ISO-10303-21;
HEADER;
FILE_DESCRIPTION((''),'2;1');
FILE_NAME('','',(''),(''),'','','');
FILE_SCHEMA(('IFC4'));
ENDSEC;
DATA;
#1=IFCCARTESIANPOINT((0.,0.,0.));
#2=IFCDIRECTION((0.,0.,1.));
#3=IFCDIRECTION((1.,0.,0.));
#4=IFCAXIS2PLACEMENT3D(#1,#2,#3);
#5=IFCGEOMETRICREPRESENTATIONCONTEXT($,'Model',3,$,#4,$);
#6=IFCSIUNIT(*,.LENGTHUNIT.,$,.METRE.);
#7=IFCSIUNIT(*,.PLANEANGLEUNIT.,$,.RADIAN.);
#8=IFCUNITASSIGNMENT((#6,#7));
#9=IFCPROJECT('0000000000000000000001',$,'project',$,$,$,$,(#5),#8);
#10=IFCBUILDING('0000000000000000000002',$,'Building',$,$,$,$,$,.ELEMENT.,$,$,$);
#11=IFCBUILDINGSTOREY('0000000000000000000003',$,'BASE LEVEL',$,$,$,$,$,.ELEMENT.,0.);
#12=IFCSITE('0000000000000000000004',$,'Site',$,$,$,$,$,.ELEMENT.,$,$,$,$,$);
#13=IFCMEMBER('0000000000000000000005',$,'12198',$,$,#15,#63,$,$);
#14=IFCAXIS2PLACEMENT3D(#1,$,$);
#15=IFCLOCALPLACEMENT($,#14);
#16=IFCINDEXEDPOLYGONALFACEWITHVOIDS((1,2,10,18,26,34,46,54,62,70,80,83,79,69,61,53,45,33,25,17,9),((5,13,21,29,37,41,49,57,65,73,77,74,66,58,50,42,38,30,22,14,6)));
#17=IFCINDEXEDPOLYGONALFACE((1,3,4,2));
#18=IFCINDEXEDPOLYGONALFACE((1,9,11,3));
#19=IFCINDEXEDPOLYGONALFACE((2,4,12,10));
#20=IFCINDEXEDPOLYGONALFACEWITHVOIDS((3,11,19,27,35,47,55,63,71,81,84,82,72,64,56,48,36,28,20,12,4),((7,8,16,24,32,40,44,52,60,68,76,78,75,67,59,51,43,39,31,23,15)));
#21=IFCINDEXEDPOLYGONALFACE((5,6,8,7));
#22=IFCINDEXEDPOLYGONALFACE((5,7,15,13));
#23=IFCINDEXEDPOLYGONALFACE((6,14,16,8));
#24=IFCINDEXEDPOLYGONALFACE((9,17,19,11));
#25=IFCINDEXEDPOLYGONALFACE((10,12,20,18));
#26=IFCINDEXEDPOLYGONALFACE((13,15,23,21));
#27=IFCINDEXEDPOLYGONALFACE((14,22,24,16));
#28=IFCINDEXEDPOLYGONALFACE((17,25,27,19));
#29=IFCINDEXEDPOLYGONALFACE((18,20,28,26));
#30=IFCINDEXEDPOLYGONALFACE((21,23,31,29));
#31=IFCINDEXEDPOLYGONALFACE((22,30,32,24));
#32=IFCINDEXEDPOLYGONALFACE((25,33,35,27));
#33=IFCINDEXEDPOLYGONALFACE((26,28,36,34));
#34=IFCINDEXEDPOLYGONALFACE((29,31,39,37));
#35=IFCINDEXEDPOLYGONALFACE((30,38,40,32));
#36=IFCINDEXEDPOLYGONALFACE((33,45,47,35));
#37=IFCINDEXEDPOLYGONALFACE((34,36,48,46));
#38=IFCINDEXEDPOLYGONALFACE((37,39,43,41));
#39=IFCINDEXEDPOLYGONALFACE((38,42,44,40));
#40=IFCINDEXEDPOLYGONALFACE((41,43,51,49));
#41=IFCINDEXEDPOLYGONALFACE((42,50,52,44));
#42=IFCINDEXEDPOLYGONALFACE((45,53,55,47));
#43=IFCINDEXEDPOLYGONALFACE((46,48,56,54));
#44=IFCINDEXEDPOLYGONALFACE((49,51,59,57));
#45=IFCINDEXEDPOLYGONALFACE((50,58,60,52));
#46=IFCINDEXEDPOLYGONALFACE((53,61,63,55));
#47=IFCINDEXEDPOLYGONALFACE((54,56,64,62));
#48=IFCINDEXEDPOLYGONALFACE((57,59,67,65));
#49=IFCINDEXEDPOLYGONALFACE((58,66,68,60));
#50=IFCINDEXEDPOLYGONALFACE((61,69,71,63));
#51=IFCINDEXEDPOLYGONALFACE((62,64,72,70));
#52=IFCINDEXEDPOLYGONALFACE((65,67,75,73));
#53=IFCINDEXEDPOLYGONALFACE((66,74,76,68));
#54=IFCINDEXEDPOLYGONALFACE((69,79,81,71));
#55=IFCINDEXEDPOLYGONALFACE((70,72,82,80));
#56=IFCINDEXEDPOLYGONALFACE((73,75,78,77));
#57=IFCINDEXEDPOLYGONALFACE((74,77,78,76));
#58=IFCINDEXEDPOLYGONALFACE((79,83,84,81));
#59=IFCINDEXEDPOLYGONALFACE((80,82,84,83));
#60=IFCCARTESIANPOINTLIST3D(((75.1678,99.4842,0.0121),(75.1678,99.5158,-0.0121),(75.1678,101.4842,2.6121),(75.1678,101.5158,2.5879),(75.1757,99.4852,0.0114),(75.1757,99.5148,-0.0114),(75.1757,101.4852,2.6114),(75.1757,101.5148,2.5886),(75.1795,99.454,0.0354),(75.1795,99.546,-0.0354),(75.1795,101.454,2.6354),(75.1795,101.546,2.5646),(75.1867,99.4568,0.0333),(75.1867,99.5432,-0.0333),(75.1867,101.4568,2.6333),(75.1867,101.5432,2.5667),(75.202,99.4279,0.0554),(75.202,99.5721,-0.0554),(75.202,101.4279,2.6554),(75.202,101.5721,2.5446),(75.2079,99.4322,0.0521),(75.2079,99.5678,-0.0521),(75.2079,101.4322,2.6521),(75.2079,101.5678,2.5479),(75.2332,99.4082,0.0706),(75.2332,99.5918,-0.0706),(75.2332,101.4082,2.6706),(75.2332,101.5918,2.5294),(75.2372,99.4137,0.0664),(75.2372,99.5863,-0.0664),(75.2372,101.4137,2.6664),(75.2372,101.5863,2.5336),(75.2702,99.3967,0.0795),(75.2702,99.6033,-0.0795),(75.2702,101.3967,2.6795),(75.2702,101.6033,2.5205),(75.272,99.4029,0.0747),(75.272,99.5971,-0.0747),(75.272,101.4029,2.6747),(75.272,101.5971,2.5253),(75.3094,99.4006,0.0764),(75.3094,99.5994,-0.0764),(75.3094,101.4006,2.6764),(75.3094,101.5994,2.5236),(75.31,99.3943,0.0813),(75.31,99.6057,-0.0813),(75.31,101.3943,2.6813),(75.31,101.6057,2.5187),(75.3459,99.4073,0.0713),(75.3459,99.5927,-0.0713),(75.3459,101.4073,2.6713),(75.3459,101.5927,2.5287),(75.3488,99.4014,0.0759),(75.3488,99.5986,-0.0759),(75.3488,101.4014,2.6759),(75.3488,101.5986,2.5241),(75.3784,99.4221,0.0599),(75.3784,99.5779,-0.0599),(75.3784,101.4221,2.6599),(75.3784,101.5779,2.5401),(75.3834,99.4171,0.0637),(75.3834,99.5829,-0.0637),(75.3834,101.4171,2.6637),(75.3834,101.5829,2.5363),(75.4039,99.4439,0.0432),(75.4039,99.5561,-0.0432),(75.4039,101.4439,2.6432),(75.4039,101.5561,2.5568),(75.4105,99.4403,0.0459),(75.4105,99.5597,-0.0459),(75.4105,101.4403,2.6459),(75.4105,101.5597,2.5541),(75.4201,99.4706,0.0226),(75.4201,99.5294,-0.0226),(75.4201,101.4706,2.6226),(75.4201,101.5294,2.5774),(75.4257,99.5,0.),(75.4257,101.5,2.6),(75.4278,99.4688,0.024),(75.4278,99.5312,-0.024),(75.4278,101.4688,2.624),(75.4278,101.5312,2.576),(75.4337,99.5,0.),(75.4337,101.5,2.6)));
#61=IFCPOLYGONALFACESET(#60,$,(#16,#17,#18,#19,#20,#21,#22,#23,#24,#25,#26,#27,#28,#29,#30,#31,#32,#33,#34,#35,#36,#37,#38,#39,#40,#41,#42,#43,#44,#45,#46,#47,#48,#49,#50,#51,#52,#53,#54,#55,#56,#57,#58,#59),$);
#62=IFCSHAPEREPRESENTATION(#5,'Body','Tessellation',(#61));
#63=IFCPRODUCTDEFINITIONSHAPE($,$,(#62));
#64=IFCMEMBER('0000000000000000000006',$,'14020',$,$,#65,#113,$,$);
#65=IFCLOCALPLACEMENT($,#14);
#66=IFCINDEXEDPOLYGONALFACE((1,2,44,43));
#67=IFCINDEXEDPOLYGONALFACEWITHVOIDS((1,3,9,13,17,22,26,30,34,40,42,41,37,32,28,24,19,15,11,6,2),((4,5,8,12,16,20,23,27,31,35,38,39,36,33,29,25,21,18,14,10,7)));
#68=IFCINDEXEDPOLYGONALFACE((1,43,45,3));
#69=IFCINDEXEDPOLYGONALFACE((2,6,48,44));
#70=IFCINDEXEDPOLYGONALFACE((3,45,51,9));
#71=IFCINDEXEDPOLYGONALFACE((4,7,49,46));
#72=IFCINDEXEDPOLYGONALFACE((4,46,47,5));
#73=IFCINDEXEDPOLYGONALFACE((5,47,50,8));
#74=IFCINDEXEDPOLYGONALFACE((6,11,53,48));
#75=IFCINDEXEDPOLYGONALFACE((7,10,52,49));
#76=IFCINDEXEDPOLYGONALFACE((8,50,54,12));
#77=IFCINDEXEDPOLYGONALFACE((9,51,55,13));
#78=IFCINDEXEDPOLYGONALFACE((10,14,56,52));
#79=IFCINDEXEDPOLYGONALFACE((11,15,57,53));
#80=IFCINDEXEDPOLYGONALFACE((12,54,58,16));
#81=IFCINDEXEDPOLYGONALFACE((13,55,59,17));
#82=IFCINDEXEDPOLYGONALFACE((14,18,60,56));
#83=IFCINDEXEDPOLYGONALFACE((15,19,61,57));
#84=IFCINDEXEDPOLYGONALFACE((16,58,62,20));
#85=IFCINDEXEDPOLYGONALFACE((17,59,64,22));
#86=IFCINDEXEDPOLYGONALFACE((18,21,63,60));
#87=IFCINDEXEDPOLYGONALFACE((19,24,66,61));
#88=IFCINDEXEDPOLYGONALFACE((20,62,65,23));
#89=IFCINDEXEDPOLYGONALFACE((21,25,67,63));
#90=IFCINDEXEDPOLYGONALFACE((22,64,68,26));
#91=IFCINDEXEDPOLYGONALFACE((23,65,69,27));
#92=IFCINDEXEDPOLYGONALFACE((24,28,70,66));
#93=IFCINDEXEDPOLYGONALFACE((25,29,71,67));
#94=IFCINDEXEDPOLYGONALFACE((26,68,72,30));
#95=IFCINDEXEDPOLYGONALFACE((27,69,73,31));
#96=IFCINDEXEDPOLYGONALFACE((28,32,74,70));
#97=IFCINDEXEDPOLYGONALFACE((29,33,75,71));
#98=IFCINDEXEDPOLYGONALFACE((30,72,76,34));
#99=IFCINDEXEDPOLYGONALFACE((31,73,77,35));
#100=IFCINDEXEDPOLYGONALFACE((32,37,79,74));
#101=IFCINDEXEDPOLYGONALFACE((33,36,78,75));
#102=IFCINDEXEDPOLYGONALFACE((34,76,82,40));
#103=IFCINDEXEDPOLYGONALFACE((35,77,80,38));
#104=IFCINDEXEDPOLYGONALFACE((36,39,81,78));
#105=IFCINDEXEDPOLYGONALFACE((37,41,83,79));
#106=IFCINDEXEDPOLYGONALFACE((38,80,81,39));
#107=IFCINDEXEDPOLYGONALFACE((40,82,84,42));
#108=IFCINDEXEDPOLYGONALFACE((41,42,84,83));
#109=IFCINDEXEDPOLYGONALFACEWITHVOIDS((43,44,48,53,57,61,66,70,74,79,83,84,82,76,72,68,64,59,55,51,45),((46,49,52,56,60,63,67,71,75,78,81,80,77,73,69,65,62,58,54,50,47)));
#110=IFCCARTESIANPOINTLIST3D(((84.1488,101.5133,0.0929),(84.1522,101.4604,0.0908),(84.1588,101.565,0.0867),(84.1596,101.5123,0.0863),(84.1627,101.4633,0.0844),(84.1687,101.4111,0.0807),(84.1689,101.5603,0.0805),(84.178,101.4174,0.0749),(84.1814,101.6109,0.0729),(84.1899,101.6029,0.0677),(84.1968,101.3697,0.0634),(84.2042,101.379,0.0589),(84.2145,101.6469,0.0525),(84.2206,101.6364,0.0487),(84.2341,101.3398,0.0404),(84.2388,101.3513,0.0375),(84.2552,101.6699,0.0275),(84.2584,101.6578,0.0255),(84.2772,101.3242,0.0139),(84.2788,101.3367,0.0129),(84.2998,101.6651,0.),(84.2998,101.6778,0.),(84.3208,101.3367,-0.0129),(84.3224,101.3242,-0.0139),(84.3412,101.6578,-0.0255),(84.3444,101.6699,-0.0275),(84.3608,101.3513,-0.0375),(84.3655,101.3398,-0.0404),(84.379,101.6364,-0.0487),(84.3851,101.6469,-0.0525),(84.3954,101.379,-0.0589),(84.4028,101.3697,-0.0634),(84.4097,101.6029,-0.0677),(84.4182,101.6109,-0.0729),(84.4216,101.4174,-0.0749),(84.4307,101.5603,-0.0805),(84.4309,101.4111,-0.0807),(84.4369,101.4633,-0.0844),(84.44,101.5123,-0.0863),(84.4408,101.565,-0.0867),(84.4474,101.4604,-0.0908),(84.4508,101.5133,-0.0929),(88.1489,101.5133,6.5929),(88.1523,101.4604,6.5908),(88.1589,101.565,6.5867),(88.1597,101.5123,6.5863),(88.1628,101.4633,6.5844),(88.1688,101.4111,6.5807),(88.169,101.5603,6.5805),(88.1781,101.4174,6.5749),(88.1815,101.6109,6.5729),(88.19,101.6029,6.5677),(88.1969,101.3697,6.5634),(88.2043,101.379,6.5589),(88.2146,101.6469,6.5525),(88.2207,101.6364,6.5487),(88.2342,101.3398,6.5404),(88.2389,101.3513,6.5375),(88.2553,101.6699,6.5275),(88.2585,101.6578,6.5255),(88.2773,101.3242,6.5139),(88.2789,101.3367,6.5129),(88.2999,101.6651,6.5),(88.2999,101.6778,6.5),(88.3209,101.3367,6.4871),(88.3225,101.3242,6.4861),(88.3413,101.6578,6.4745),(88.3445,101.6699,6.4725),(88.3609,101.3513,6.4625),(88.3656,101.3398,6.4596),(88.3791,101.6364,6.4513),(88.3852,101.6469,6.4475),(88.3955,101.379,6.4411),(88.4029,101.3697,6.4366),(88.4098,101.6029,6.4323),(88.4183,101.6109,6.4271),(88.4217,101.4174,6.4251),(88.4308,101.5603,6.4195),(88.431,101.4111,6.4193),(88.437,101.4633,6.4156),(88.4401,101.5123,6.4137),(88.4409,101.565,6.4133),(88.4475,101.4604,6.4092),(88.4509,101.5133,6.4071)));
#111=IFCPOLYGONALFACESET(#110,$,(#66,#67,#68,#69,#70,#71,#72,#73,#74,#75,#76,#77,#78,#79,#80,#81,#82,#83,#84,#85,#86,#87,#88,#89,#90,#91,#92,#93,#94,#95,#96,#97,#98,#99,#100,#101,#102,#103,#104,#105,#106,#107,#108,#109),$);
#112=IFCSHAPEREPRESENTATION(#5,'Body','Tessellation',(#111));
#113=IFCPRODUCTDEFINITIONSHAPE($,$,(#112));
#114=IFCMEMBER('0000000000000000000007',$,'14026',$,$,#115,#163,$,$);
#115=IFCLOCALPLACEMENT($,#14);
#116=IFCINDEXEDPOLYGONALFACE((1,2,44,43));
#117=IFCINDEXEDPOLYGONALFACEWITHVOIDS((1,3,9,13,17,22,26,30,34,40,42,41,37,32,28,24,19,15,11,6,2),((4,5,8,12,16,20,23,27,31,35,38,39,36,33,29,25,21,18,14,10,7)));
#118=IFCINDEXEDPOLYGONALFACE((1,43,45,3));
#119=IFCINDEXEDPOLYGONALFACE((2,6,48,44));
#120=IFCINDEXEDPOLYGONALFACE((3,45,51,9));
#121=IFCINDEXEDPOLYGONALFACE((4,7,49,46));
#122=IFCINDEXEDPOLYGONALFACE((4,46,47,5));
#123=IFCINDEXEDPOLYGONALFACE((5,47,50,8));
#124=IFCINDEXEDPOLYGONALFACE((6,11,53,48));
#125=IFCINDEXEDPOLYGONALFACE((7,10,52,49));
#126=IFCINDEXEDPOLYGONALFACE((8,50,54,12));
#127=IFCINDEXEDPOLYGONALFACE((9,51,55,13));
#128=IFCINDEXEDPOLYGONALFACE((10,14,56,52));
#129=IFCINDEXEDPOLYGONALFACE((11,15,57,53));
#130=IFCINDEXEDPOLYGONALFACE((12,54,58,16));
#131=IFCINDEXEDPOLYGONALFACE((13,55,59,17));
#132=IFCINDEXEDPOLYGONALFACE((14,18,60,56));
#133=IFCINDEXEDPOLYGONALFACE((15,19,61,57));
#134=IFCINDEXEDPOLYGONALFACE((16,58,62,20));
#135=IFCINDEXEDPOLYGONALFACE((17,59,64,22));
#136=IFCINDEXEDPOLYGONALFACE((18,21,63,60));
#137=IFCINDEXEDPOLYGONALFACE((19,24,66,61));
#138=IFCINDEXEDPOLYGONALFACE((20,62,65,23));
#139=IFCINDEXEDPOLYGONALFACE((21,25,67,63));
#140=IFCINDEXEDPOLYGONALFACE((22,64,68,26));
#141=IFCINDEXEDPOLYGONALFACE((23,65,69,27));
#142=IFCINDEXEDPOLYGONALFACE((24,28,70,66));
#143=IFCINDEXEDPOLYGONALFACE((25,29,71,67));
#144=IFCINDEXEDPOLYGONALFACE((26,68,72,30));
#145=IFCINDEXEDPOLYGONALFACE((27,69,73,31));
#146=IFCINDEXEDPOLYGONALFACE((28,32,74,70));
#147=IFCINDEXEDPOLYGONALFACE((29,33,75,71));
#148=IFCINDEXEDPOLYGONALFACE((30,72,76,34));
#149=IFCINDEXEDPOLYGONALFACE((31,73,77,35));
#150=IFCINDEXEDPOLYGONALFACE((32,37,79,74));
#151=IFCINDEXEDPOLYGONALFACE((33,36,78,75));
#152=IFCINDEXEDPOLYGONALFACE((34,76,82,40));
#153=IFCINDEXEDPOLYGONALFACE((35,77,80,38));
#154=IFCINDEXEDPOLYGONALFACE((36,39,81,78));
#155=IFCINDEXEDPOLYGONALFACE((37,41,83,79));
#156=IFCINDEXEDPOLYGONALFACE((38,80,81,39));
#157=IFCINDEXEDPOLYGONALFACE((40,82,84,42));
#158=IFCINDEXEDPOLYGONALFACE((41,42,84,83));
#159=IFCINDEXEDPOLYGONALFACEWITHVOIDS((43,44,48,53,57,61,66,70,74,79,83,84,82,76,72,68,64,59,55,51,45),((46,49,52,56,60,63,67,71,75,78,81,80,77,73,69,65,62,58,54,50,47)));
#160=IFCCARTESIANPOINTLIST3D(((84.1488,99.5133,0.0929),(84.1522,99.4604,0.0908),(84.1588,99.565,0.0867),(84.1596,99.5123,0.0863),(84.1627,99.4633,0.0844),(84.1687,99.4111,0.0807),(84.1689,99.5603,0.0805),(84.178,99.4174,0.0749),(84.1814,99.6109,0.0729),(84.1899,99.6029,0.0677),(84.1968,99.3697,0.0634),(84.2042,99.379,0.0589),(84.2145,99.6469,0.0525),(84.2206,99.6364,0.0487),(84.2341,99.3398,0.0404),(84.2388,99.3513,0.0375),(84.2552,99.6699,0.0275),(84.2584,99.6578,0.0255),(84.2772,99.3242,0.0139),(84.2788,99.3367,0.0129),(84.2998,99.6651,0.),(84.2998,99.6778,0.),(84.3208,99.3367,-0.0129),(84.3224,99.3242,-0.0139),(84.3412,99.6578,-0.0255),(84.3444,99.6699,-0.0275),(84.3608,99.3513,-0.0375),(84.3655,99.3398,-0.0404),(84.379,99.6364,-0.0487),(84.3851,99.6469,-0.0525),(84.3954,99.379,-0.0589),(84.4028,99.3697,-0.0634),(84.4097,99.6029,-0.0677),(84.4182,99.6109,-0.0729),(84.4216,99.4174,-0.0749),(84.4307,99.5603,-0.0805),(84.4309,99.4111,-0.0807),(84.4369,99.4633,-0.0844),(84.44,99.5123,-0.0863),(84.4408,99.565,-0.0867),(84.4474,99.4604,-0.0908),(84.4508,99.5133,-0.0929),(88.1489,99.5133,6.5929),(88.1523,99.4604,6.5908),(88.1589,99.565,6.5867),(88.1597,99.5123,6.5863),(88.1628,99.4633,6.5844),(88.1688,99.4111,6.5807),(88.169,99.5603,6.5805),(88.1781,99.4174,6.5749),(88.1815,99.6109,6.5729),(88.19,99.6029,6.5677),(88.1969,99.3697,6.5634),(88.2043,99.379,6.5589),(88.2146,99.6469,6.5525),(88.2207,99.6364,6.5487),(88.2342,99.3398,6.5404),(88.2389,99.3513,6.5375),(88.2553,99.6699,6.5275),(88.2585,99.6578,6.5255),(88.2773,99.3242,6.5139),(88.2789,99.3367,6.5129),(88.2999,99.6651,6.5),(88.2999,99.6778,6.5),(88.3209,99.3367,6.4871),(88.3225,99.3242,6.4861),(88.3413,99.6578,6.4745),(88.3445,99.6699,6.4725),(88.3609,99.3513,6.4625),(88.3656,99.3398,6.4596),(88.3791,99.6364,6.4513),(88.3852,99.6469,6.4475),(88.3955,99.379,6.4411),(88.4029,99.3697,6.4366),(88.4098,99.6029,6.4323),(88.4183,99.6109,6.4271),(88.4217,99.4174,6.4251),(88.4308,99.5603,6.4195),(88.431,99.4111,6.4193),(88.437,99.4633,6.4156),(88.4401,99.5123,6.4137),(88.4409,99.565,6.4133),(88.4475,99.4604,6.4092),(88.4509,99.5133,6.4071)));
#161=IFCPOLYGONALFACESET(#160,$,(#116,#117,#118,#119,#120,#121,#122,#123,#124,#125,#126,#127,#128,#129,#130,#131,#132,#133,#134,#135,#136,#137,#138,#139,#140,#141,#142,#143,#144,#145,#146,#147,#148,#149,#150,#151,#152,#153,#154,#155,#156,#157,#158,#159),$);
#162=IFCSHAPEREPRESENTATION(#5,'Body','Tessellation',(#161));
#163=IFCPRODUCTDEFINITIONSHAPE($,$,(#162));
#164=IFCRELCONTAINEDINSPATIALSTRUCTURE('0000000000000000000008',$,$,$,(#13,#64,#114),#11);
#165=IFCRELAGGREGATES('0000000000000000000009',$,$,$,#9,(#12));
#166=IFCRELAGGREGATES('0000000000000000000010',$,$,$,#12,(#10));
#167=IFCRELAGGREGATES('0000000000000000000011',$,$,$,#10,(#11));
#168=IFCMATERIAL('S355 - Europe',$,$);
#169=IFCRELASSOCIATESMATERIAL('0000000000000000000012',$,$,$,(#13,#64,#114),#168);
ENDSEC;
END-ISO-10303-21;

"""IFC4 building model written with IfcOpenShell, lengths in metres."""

from ifc_helpers import new_model, si_unit, frame, origin_with_axes, origin_2d_with_axis, place, context, project, spatial, hollow_circle, extrude, material, material_profile, profile_set, profile_usage, element, save


model = new_model("IFC4")

# Units and contexts
model_context = context("Model", 3, world=origin_with_axes())
ifc_project = project(units=[si_unit("LENGTHUNIT", "METRE"), si_unit("PLANEANGLEUNIT", "RADIAN")], contexts=[model_context])

# Site, building, storey
site = spatial("IfcSite", under=ifc_project, Name="Site", CompositionType="ELEMENT")
building = spatial("IfcBuilding", under=site, Name="Building", CompositionType="ELEMENT")
storey = spatial("IfcBuildingStorey", under=building, Name="BASE LEVEL", CompositionType="ELEMENT", Elevation=0.0)

# Shared definitions
ifc_material = material(Name="S355 - Europe")

# Members
ifc_material_profile_1 = material_profile(ifc_material, hollow_circle(Radius=0.1337, WallThickness=0.008, at=origin_2d_with_axis()))
ifc_profile_set_1 = profile_set([ifc_material_profile_1])
ifc_profile_usage_1 = profile_usage(ifc_profile_set_1, cardinal=10)
member_1_placement = place(None, frame((75.3, 101.5, 2.6), z_axis=(0.0, -0.609711, -0.792624), x_axis=(1.0, 0.0, 0.0)))
element("IfcMember", 1, at=member_1_placement, inside=storey, material=ifc_profile_usage_1, Name="12198", context=model_context, shape_type="SweptSolid", body=[
    extrude(hollow_circle(Radius=0.1337, WallThickness=0.008, at=origin_2d_with_axis()), origin_with_axes(), (0.0, 0.0, 1.0), 3.2802),
])
ifc_material_profile_2 = material_profile(ifc_material, hollow_circle(Radius=0.1778, WallThickness=0.0127, at=origin_2d_with_axis()))
ifc_profile_set_2 = profile_set([ifc_material_profile_2])
ifc_profile_usage_2 = profile_usage(ifc_profile_set_2, cardinal=10)
member_2_placement = place(None, frame((84.2998, 101.5, 0.0), z_axis=(0.524107, 0.0, 0.851652), x_axis=(0.0, 1.0, 0.0)))
element("IfcMember", 2, at=member_2_placement, inside=storey, material=ifc_profile_usage_2, Name="14020", context=model_context, shape_type="SweptSolid", body=[
    extrude(hollow_circle(Radius=0.1778, WallThickness=0.0127, at=origin_2d_with_axis()), origin_with_axes(), (0.0, 0.0, 1.0), 7.6322),
])
ifc_material_profile_3 = material_profile(ifc_material, hollow_circle(Radius=0.1778, WallThickness=0.0127, at=origin_2d_with_axis()))
ifc_profile_set_3 = profile_set([ifc_material_profile_3])
ifc_profile_usage_3 = profile_usage(ifc_profile_set_3, cardinal=10)
member_3_placement = place(None, frame((84.2998, 99.5, 0.0), z_axis=(0.524107, 0.0, 0.851652), x_axis=(0.0, 1.0, 0.0)))
element("IfcMember", 3, at=member_3_placement, inside=storey, material=ifc_profile_usage_3, Name="14026", context=model_context, shape_type="SweptSolid", body=[
    extrude(hollow_circle(Radius=0.1778, WallThickness=0.0127, at=origin_2d_with_axis()), origin_with_axes(), (0.0, 0.0, 1.0), 7.6322),
])

save(model, "model.ifc")
